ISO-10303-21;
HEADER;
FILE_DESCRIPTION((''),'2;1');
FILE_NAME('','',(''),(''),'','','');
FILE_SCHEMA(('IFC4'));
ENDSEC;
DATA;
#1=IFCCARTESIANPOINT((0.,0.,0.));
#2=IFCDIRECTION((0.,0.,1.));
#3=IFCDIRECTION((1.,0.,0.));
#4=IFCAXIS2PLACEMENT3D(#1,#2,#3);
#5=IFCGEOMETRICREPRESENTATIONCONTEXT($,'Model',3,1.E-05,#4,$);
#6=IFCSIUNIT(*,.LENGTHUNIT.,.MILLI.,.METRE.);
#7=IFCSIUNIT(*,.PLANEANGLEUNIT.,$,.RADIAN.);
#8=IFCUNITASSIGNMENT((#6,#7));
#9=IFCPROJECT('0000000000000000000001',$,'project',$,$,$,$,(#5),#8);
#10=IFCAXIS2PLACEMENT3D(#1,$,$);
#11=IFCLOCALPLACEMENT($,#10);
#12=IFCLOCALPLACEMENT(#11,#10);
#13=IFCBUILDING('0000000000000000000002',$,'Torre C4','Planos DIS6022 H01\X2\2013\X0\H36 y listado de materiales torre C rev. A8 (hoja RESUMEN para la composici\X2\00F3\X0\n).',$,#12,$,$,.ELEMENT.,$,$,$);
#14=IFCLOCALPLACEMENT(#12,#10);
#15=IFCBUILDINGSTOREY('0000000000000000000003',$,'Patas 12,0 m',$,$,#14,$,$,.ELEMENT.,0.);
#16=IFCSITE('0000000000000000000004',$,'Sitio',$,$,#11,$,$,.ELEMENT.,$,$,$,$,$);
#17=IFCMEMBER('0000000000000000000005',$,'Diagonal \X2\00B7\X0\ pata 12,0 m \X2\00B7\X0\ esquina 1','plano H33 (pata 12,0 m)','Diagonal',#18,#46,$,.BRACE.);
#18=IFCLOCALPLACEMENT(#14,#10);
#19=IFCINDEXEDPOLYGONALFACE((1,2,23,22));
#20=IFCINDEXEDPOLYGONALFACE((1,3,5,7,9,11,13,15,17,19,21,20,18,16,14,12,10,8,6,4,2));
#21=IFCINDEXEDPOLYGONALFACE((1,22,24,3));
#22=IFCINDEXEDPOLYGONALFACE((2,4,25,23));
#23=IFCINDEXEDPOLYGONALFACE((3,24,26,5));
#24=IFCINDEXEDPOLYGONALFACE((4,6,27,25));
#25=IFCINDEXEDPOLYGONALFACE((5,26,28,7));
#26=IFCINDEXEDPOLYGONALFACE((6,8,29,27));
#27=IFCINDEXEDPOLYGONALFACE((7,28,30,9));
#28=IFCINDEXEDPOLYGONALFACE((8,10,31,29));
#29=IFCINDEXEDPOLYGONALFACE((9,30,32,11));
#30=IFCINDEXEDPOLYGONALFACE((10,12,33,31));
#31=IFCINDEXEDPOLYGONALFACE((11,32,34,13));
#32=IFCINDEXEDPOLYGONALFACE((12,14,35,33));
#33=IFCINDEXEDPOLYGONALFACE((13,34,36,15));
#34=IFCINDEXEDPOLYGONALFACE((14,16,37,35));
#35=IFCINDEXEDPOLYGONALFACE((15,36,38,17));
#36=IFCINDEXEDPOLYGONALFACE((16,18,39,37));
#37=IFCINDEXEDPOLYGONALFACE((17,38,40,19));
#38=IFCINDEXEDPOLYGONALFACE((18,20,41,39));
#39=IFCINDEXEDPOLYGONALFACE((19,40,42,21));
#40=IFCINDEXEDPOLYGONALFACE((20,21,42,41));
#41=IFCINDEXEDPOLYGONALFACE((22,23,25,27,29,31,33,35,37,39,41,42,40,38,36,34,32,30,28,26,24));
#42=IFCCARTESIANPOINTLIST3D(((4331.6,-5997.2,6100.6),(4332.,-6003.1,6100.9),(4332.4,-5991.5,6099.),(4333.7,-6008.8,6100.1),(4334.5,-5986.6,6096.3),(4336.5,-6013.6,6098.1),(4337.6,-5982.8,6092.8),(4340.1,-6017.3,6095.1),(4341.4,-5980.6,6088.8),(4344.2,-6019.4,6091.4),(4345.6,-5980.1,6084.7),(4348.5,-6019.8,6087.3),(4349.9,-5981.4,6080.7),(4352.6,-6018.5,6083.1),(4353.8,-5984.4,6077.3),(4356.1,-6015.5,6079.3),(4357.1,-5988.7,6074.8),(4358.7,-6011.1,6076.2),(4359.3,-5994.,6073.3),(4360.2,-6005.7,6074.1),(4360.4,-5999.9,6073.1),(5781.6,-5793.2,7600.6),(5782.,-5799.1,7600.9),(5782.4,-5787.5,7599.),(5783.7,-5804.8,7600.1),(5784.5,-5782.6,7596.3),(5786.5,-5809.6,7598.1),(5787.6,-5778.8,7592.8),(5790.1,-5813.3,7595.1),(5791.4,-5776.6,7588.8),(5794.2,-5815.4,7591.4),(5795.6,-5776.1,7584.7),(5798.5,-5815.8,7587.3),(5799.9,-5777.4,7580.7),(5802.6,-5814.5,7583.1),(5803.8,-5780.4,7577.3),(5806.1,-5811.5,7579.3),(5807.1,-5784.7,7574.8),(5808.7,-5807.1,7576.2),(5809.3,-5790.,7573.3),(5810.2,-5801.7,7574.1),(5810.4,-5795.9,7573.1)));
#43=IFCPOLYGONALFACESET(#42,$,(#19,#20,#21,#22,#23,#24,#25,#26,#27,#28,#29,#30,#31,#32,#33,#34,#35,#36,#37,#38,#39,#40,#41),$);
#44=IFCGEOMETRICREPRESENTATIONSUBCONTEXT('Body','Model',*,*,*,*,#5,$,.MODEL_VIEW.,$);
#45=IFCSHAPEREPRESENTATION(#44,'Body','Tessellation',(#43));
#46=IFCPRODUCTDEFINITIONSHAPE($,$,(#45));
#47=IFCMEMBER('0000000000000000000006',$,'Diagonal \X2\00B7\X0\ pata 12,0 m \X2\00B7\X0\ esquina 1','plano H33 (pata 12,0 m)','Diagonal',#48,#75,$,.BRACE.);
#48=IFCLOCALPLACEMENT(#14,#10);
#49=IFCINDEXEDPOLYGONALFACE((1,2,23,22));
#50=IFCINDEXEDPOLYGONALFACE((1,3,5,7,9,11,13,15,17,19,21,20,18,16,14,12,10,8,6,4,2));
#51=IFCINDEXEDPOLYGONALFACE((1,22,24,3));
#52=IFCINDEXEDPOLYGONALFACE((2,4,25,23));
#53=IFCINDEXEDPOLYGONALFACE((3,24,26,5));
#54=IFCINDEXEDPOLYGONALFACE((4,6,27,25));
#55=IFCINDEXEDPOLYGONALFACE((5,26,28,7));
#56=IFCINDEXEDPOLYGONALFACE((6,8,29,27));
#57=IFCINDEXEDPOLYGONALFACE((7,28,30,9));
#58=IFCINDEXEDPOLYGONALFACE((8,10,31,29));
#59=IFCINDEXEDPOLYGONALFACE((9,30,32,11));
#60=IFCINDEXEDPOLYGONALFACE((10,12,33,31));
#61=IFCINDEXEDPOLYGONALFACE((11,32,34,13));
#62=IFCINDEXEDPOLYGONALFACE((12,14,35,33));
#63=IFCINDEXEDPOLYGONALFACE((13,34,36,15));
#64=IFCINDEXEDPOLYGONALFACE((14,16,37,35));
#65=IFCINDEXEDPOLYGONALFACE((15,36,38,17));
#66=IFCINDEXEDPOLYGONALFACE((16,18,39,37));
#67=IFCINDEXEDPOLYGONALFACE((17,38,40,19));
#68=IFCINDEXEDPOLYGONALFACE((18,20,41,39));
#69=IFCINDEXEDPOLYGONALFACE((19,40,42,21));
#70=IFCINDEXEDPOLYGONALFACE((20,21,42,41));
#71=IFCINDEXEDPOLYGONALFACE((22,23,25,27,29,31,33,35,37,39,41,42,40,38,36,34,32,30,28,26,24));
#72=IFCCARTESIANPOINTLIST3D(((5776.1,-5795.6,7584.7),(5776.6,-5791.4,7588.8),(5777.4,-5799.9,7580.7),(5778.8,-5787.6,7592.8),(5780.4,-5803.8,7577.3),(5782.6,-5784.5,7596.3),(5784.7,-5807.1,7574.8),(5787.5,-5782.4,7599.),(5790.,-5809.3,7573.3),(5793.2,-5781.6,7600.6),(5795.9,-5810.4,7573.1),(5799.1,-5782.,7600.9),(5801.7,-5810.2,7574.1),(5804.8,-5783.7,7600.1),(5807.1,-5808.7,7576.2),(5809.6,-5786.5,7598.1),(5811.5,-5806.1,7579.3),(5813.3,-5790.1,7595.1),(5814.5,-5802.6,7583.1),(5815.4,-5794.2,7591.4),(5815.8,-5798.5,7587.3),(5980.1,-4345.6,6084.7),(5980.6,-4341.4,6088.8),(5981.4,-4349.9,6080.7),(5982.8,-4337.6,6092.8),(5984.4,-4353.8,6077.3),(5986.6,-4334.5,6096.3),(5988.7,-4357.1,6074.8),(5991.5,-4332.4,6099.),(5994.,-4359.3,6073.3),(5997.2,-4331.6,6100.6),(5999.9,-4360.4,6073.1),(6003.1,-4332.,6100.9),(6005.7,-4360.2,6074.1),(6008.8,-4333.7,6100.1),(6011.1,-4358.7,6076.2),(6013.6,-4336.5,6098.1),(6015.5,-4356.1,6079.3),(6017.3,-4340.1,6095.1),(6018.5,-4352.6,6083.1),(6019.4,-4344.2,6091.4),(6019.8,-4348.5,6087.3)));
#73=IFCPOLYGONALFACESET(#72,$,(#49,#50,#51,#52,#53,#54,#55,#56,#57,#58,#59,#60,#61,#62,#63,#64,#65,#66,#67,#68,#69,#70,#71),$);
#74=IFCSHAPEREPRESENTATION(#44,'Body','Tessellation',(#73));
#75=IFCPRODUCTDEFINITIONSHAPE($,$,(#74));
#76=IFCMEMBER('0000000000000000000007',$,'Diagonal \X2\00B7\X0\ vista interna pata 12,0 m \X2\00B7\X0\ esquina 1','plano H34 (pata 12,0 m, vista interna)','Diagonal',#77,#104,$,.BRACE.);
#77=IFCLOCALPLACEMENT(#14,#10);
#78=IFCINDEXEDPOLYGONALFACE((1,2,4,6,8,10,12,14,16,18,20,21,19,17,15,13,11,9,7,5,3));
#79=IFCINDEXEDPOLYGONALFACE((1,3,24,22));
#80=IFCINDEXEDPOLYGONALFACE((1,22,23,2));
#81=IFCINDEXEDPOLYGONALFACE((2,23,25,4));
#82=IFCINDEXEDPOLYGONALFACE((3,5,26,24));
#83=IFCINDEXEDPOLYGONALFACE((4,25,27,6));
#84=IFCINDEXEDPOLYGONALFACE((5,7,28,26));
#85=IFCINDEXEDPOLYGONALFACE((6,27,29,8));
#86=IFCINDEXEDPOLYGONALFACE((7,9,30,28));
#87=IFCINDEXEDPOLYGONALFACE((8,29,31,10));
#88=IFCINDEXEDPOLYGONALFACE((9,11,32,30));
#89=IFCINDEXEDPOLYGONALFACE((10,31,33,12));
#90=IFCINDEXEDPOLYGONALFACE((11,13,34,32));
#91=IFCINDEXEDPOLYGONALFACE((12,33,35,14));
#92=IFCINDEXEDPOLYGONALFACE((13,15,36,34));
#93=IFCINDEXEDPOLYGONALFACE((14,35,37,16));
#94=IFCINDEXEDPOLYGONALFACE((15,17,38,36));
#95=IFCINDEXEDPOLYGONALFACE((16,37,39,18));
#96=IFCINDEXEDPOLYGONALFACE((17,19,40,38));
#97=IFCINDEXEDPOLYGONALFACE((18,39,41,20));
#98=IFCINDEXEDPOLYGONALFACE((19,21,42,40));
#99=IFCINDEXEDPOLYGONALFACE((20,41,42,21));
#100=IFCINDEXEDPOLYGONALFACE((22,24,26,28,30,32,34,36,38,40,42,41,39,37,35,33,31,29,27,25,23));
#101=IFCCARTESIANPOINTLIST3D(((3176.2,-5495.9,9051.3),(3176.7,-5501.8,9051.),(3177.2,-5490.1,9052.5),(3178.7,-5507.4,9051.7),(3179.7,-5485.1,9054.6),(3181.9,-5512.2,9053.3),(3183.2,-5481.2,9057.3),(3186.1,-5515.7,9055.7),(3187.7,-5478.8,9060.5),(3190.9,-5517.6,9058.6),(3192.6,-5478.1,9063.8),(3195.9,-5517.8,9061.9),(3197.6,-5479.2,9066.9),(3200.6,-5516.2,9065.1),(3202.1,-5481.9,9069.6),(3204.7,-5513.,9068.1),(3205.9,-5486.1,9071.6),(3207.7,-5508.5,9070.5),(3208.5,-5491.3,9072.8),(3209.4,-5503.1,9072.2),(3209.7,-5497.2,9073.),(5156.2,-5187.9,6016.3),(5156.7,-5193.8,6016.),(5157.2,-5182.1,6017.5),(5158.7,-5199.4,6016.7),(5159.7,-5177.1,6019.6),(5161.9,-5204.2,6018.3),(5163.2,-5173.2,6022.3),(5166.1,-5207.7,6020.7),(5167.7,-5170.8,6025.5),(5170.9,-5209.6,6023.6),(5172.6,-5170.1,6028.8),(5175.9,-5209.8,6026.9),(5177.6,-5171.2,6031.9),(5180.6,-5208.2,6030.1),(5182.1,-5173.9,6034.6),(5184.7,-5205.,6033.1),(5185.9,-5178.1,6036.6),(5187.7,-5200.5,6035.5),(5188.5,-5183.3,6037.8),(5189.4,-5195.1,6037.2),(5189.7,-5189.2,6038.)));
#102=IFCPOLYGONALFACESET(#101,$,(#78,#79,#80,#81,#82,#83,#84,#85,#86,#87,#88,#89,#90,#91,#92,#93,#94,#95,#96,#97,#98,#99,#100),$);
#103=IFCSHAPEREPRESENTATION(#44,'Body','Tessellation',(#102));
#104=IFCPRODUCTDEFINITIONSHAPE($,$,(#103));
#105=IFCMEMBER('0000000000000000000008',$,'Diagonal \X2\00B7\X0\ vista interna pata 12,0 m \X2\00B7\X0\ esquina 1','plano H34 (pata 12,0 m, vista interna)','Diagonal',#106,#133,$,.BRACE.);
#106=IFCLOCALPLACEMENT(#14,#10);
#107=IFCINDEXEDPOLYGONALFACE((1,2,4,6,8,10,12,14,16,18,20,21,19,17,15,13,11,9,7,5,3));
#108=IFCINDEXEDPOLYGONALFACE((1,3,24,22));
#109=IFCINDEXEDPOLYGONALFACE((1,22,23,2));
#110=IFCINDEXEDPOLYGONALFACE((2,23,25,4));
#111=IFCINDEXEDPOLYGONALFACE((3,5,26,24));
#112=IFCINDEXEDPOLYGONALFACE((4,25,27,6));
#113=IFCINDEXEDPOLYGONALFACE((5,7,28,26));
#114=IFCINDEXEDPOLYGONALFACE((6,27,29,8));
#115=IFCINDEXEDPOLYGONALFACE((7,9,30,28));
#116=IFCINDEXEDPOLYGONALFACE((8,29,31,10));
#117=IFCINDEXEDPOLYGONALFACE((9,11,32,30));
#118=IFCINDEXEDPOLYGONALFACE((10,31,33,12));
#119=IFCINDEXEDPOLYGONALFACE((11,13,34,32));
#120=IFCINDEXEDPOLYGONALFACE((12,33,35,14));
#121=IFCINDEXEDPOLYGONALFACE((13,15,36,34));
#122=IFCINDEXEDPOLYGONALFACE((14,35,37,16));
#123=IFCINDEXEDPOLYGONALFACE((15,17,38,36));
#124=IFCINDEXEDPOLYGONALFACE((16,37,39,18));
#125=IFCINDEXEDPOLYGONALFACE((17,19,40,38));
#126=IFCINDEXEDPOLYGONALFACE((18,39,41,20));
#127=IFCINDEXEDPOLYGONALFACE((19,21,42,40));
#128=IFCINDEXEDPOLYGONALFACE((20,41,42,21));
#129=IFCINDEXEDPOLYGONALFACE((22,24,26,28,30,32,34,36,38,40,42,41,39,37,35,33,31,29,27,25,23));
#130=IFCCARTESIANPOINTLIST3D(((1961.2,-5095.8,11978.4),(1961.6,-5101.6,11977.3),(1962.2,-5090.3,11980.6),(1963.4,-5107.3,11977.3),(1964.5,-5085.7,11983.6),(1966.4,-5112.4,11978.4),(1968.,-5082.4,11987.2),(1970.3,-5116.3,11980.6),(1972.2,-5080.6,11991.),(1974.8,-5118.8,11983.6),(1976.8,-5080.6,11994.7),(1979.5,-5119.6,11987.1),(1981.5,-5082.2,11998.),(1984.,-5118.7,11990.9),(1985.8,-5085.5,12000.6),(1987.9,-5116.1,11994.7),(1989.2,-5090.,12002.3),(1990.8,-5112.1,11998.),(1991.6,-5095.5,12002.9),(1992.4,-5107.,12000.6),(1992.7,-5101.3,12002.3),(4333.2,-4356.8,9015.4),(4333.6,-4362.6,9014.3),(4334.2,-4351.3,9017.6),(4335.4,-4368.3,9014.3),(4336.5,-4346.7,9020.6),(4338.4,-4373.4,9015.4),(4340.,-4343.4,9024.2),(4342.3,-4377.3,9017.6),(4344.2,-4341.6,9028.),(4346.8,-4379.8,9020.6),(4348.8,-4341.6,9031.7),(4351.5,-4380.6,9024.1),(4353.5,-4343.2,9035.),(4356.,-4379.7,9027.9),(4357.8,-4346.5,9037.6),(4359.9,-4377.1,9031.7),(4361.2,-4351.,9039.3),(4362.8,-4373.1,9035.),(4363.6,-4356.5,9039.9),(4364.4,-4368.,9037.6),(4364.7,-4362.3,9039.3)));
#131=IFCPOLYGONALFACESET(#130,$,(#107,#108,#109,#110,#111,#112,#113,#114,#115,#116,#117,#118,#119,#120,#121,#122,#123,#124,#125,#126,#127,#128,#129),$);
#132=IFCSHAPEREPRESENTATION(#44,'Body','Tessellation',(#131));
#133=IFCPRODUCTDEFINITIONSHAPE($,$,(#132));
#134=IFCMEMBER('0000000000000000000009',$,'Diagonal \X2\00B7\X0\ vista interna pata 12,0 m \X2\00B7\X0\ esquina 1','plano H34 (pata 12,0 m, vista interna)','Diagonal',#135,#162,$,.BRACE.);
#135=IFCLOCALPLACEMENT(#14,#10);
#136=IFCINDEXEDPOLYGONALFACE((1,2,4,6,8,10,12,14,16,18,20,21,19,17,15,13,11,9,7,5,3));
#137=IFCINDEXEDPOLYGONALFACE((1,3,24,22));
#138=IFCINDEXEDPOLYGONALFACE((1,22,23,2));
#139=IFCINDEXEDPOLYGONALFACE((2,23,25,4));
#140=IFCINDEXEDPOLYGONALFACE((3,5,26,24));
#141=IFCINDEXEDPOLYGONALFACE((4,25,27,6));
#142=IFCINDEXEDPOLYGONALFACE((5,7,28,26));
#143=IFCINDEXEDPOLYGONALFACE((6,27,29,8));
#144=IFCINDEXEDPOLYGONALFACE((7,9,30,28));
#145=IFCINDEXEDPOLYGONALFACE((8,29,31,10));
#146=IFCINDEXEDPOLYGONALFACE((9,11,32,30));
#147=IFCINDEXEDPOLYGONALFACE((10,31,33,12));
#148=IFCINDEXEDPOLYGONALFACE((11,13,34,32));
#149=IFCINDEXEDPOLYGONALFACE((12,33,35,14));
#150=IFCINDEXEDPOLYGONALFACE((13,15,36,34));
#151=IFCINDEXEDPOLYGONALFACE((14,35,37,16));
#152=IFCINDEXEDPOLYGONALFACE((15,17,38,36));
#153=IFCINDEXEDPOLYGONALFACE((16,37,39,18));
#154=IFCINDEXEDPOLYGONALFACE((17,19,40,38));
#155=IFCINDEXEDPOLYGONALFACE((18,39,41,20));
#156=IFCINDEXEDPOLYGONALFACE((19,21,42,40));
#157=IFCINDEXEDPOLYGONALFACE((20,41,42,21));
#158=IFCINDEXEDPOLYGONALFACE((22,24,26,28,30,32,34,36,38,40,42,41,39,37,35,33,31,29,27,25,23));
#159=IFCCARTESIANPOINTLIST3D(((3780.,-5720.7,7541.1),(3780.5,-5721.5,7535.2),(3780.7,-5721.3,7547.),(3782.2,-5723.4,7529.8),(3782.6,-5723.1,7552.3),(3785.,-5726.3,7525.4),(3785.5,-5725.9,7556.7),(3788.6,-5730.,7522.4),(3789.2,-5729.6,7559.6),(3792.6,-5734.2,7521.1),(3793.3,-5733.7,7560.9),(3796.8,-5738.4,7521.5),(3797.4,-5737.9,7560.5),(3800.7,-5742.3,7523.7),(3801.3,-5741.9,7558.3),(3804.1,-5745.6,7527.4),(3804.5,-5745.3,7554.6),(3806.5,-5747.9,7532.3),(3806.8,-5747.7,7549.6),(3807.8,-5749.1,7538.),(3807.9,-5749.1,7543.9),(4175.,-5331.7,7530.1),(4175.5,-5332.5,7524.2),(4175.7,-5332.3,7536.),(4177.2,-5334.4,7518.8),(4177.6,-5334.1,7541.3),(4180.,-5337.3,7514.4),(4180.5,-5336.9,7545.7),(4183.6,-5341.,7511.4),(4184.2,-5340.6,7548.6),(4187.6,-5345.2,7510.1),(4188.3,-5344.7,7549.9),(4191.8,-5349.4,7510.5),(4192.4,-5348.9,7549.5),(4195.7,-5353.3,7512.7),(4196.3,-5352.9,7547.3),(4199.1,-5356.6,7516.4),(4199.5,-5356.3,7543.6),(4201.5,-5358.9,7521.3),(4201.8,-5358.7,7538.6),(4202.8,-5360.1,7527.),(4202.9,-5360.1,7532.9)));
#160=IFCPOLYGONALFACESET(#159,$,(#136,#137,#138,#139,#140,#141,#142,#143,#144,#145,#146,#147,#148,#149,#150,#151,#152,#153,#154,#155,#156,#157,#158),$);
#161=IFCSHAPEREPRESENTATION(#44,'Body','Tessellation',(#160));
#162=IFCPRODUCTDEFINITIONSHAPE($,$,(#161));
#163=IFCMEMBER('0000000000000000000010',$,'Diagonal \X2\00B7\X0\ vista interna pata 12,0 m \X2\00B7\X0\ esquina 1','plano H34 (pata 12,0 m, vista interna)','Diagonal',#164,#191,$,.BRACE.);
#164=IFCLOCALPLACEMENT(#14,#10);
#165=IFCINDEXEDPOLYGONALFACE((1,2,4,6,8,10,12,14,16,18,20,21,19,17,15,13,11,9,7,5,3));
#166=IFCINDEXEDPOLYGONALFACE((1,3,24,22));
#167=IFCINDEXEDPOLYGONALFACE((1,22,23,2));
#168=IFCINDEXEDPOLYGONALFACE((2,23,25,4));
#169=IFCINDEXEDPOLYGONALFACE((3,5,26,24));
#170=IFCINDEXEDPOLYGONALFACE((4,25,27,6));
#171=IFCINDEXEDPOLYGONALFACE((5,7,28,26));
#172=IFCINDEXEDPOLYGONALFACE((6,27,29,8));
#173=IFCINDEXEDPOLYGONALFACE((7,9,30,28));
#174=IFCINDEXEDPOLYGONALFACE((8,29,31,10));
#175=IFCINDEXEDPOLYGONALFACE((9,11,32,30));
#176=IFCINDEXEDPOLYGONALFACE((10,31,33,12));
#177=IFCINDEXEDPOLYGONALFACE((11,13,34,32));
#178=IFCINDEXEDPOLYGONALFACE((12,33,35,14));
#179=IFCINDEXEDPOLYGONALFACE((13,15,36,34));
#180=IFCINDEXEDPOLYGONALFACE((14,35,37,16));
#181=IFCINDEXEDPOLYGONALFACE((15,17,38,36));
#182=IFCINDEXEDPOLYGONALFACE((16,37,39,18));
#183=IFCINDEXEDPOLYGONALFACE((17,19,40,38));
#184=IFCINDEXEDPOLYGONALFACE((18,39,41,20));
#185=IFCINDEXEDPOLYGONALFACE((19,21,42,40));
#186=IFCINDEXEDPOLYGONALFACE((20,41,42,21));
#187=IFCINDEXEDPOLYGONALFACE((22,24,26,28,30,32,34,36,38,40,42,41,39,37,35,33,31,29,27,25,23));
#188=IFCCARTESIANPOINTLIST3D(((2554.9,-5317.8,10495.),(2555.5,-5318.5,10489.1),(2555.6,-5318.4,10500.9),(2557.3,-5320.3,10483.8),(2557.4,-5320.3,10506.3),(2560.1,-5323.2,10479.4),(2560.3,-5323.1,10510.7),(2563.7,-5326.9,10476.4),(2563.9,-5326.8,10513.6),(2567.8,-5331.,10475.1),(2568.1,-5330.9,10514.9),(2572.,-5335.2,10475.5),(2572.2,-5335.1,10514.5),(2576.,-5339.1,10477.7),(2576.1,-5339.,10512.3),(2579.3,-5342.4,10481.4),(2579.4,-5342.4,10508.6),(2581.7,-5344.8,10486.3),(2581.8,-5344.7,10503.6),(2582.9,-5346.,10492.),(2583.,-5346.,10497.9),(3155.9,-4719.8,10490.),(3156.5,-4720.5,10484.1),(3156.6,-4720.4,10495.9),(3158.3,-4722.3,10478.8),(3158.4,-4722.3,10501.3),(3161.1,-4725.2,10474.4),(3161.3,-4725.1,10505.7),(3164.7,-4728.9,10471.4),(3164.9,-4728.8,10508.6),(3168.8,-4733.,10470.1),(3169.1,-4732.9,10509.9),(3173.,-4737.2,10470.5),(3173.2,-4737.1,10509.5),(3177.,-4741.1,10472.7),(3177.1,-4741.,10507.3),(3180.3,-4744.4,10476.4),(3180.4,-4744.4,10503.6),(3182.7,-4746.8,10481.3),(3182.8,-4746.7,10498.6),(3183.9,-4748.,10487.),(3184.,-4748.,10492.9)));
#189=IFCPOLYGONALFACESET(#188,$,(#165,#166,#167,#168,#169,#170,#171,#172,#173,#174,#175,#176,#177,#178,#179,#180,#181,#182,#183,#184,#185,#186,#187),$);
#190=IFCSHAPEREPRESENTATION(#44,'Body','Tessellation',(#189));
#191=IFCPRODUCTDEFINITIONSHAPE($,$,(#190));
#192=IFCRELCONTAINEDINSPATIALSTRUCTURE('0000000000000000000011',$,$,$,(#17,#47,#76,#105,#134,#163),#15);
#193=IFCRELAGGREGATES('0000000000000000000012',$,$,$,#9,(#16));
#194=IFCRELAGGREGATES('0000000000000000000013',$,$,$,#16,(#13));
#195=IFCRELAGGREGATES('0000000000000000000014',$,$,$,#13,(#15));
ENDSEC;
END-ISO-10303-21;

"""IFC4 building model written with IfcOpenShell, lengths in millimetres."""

from ifc_helpers import new_model, si_unit, frame, origin, origin_with_axes, place, context, subcontext, project, spatial, circle, extrude, element, save


model = new_model("IFC4")

# Units and contexts
model_context = context("Model", 3, precision=1e-05, world=origin_with_axes())
body_context = subcontext(model_context, "Body", "Model", "MODEL_VIEW")
ifc_project = project(units=[si_unit("LENGTHUNIT", "METRE", prefix="MILLI"), si_unit("PLANEANGLEUNIT", "RADIAN")], contexts=[model_context])

# Site, building, storey
site_placement = place(None, origin())
site = spatial("IfcSite", under=ifc_project, at=site_placement, Name="Sitio", CompositionType="ELEMENT")
building_placement = place(site_placement, origin())
building = spatial("IfcBuilding", under=site, at=building_placement, Name="Torre C4", Description="Planos DIS6022 H01–H36 y listado de materiales torre C rev. A8 (hoja RESUMEN para la composición).", CompositionType="ELEMENT")
storey_placement = place(building_placement, origin())
storey = spatial("IfcBuildingStorey", under=building, at=storey_placement, Name="Patas 12,0 m", CompositionType="ELEMENT", Elevation=0.0)

# Members
for number, where, z_axis, x_axis, name in (
    (1, (5796.0, -5796.0, 7587.0), (-0.691723, -0.097318, -0.715576), (-0.422231, 0.858369, 0.291418), "Diagonal · pata 12,0 m · esquina 1"),
    (2, (5796.0, -5796.0, 7587.0), (0.097318, 0.691723, -0.715576), (-0.858369, 0.422231, 0.291418), "Diagonal · pata 12,0 m · esquina 1"),
):
    element("IfcMember", number, at=place(storey_placement, frame(where, z_axis=z_axis, x_axis=x_axis)), inside=storey, Name=name, Description="plano H33 (pata 12,0 m)", ObjectType="Diagonal", PredefinedType="BRACE", context=body_context, shape_type="SweptSolid", body=[
        extrude(circle(Radius=20.0), None, (0.0, 0.0, 1.0), 2096.2),
    ])
member_1_placement = place(storey_placement, frame((3193.0, -5498.0, 9062.0), z_axis=(0.544431, 0.084689, -0.834519), x_axis=(-0.487957, 0.841204, -0.23297)))
element("IfcMember", 3, at=member_1_placement, inside=storey, Name="Diagonal · vista interna pata 12,0 m · esquina 1", Description="plano H34 (pata 12,0 m, vista interna)", ObjectType="Diagonal", PredefinedType="BRACE", context=body_context, shape_type="SweptSolid", body=[
    extrude(circle(Radius=20.0), None, (0.0, 0.0, 1.0), 3636.8),
])
member_2_placement = place(storey_placement, frame((1977.0, -5100.0, 11990.0), z_axis=(0.613433, 0.191116, -0.766274), x_axis=(-0.451684, 0.88082, -0.141907)))
element("IfcMember", 4, at=member_2_placement, inside=storey, Name="Diagonal · vista interna pata 12,0 m · esquina 1", Description="plano H34 (pata 12,0 m, vista interna)", ObjectType="Diagonal", PredefinedType="BRACE", context=body_context, shape_type="SweptSolid", body=[
    extrude(circle(Radius=20.0), None, (0.0, 0.0, 1.0), 3866.8),
])
member_3_placement = place(storey_placement, frame((3794.0, -5735.0, 7541.0), z_axis=(0.712357, 0.701537, -0.019838), x_axis=(-0.701628, 0.712537, 0.003067)))
element("IfcMember", 5, at=member_3_placement, inside=storey, Name="Diagonal · vista interna pata 12,0 m · esquina 1", Description="plano H34 (pata 12,0 m, vista interna)", ObjectType="Diagonal", PredefinedType="BRACE", context=body_context, shape_type="SweptSolid", body=[
    extrude(circle(Radius=20.0), None, (0.0, 0.0, 1.0), 554.5),
])
member_4_placement = place(storey_placement, frame((2569.0, -5332.0, 10495.0), z_axis=(0.708861, 0.705323, -0.005897), x_axis=(-0.705328, 0.70888, 0.001599)))
element("IfcMember", 6, at=member_4_placement, inside=storey, Name="Diagonal · vista interna pata 12,0 m · esquina 1", Description="plano H34 (pata 12,0 m, vista interna)", ObjectType="Diagonal", PredefinedType="BRACE", context=body_context, shape_type="SweptSolid", body=[
    extrude(circle(Radius=20.0), None, (0.0, 0.0, 1.0), 847.8),
])

save(model, "model.ifc")
